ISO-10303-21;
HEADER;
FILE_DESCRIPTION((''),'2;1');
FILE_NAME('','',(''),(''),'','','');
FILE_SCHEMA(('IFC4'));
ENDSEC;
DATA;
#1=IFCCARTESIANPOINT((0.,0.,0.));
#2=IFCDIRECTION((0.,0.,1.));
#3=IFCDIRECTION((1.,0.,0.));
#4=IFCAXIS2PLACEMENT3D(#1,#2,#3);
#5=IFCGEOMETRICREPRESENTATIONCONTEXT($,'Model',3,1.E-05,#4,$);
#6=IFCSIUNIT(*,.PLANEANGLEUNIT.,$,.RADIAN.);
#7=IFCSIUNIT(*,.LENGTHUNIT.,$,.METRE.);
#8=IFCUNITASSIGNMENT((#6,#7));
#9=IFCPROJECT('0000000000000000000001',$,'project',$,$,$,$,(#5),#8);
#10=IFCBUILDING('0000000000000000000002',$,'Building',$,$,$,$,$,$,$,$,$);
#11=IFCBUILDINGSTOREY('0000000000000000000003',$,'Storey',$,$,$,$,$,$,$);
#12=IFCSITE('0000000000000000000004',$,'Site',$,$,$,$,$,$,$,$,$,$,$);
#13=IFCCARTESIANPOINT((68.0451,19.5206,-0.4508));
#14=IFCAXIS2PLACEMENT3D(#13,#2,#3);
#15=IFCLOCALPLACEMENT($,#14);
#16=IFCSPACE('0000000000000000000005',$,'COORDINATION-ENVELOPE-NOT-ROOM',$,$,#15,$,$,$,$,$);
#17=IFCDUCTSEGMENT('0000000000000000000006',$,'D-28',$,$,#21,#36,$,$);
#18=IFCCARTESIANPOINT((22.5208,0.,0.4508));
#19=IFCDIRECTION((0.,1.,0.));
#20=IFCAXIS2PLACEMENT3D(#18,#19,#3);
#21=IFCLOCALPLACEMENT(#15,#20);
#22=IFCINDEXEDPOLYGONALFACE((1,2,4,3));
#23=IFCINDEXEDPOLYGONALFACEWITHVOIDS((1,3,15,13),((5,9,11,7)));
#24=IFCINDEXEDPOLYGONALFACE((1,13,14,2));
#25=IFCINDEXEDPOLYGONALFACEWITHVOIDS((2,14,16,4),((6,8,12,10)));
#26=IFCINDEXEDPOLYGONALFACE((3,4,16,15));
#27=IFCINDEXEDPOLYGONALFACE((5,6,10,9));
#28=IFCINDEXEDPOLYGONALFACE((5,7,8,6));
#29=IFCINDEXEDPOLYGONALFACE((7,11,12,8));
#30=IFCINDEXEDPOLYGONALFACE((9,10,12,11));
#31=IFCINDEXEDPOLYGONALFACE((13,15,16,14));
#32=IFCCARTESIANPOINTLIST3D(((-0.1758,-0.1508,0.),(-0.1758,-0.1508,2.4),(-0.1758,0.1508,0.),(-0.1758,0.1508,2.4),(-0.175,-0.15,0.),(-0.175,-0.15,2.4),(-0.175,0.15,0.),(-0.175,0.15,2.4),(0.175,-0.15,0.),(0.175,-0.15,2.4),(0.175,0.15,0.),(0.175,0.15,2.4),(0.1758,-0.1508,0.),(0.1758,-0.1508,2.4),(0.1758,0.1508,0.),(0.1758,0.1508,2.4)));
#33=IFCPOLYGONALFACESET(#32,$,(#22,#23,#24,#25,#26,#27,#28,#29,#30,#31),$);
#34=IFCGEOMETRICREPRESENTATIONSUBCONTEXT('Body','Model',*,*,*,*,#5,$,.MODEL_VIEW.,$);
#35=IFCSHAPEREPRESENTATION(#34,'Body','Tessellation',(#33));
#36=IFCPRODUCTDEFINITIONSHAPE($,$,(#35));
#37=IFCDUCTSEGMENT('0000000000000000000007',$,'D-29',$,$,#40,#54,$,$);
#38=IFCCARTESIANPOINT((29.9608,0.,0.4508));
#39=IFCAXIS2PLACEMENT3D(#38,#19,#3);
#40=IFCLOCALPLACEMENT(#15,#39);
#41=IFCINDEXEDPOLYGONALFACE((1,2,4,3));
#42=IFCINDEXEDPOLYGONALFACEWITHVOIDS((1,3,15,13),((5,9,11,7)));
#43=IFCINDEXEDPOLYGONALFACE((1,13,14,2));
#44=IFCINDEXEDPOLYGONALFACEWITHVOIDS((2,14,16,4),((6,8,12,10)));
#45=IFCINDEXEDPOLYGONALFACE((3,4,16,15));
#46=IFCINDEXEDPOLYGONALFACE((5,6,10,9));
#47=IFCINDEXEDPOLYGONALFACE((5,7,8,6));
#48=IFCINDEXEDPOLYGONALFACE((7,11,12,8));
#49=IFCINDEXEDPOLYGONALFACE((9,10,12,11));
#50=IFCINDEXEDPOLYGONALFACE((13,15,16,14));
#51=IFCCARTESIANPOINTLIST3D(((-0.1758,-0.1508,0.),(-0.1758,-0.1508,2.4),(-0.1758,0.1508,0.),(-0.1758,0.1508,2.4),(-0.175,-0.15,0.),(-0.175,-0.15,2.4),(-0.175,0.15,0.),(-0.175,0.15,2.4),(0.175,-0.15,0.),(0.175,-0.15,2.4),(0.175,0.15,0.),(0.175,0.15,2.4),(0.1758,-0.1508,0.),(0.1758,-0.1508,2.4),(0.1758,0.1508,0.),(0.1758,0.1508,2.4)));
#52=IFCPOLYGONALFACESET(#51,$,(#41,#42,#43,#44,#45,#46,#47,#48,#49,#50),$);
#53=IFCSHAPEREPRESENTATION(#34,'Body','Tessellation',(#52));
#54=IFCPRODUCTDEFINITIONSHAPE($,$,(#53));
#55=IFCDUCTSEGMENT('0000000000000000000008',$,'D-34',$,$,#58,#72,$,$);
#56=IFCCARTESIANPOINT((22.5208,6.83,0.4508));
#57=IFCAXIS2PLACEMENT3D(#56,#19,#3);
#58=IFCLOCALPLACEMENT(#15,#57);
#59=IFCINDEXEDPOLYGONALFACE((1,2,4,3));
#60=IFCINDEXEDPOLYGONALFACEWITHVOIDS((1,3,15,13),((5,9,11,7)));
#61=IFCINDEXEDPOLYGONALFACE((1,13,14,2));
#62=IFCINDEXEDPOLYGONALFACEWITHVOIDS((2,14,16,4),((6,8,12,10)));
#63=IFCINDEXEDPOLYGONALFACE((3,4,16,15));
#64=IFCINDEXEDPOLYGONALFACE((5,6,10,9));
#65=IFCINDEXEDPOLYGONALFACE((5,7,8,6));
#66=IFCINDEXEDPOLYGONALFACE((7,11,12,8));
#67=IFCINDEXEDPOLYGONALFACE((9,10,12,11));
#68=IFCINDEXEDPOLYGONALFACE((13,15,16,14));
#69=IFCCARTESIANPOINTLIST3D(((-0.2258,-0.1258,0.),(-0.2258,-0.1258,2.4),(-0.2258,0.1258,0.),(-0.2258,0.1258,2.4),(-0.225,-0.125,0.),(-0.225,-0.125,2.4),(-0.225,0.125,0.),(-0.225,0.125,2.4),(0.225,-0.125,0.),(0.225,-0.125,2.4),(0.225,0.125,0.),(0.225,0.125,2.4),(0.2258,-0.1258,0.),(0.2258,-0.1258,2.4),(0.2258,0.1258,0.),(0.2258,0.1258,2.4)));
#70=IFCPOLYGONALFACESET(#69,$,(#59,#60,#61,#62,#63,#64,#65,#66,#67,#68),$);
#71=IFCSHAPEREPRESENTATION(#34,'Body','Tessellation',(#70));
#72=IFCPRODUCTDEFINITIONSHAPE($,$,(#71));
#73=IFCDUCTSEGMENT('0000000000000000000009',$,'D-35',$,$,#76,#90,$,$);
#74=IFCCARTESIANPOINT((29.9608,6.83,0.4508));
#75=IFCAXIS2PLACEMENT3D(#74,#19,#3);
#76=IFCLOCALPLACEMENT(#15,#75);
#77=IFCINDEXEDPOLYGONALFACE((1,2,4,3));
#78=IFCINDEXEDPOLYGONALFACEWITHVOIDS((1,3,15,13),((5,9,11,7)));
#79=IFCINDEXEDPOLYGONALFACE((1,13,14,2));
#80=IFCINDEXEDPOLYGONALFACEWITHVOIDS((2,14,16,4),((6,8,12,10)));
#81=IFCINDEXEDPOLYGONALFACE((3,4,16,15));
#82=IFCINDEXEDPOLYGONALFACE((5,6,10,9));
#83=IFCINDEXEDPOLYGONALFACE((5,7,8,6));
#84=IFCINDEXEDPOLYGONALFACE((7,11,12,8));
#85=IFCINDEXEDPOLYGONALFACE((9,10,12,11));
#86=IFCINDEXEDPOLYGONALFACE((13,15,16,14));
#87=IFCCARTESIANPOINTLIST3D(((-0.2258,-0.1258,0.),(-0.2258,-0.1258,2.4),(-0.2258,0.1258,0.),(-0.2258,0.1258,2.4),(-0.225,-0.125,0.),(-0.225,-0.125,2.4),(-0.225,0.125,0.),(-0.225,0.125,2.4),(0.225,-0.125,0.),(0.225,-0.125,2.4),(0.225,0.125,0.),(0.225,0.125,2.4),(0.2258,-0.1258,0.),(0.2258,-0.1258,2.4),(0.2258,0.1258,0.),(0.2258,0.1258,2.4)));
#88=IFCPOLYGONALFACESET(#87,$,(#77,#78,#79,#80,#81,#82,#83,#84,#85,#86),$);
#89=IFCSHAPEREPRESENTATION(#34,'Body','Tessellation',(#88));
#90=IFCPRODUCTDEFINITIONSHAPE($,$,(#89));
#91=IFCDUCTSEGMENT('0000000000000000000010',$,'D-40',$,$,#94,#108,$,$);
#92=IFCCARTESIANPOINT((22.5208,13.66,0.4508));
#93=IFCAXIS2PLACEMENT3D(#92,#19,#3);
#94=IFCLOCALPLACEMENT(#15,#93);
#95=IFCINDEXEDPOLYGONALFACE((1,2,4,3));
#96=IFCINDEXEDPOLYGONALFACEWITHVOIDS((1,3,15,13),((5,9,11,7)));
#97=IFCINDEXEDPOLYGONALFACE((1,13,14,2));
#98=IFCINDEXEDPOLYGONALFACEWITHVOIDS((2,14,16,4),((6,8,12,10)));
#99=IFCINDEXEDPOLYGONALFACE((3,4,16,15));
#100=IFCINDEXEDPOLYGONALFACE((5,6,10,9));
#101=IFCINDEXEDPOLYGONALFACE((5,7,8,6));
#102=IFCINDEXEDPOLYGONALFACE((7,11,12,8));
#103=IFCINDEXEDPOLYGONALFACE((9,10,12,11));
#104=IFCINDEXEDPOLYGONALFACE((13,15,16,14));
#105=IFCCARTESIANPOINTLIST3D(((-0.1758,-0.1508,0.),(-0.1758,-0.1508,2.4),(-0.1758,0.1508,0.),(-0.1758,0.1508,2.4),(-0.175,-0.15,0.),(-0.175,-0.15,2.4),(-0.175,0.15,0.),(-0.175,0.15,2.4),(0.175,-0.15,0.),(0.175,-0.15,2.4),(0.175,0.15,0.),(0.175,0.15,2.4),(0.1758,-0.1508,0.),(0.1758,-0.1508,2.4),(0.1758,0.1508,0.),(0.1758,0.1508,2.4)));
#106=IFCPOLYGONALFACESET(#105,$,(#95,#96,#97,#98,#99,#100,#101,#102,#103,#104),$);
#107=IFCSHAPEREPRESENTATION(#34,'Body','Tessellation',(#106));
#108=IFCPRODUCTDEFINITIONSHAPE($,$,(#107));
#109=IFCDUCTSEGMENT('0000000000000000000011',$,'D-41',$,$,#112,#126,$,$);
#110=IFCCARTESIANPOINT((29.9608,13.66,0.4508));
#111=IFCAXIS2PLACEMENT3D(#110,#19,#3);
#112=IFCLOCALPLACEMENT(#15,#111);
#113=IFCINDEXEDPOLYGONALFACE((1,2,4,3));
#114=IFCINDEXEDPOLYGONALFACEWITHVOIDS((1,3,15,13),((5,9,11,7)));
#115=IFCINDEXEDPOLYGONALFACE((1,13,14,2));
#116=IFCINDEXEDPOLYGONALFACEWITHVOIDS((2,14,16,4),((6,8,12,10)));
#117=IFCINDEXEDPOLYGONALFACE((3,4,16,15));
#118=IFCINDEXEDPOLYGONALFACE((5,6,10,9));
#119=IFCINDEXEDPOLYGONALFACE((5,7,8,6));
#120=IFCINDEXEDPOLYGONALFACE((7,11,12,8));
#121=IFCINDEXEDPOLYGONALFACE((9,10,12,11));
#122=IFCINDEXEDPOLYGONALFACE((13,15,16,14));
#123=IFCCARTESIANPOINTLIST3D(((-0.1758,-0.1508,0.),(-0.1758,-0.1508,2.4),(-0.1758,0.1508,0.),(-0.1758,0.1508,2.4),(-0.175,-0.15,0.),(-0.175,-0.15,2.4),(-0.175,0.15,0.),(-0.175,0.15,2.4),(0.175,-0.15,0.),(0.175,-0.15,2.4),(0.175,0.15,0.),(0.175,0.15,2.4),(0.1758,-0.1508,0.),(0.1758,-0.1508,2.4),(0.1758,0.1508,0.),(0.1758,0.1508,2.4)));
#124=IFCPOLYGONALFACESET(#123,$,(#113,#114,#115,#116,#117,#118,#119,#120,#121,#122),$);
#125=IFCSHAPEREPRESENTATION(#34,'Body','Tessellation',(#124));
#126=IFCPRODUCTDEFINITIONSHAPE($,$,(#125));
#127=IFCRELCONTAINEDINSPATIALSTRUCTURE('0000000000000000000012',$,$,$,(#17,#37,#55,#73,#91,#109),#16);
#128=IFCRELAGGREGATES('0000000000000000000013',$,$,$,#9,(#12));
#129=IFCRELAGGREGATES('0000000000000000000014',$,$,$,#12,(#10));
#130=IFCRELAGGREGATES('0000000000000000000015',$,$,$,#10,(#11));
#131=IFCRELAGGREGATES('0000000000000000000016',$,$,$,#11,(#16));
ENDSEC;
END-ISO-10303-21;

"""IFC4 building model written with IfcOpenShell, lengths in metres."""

from ifc_helpers import new_model, si_unit, frame, origin, origin_with_axes, place, context, subcontext, project, spatial, hollow_rectangle, extrude, element, save


model = new_model("IFC4")

# Units and contexts
model_context = context("Model", 3, precision=1e-05, world=origin_with_axes())
body_context = subcontext(model_context, "Body", "Model", "MODEL_VIEW")
ifc_project = project(units=[si_unit("PLANEANGLEUNIT", "RADIAN"), si_unit("LENGTHUNIT", "METRE")], contexts=[model_context])

# Site, building, storey, space
site = spatial("IfcSite", under=ifc_project, Name="Site")
building = spatial("IfcBuilding", under=site, Name="Building")
storey = spatial("IfcBuildingStorey", under=building, Name="Storey")
space_placement = place(None, frame((68.0451, 19.5206, -0.4508), z_axis=(0.0, 0.0, 1.0), x_axis=(1.0, 0.0, 0.0)))
space = spatial("IfcSpace", under=storey, at=space_placement, Name="COORDINATION-ENVELOPE-NOT-ROOM")

# Duct segments
for number, where, z_axis, x_axis, name in (
    (1, (22.5208, 0.0, 0.4508), (0.0, 1.0, 0.0), (1.0, 0.0, 0.0), "D-28"),
    (2, (29.9608, 0.0, 0.4508), (0.0, 1.0, 0.0), (1.0, 0.0, 0.0), "D-29"),
):
    element("IfcDuctSegment", number, at=place(space_placement, frame(where, z_axis=z_axis, x_axis=x_axis)), inside=space, Name=name, context=body_context, shape_type="SweptSolid", body=[
        extrude(hollow_rectangle(XDim=0.3516, YDim=0.3016, WallThickness=0.0008), origin(), (0.0, 0.0, 1.0), 2.4),
    ])
for number, where, z_axis, x_axis, name in (
    (3, (22.5208, 6.83, 0.4508), (0.0, 1.0, 0.0), (1.0, 0.0, 0.0), "D-34"),
    (4, (29.9608, 6.83, 0.4508), (0.0, 1.0, 0.0), (1.0, 0.0, 0.0), "D-35"),
):
    element("IfcDuctSegment", number, at=place(space_placement, frame(where, z_axis=z_axis, x_axis=x_axis)), inside=space, Name=name, context=body_context, shape_type="SweptSolid", body=[
        extrude(hollow_rectangle(XDim=0.4516, YDim=0.2516, WallThickness=0.0008), origin(), (0.0, 0.0, 1.0), 2.4),
    ])
for number, where, z_axis, x_axis, name in (
    (5, (22.5208, 13.66, 0.4508), (0.0, 1.0, 0.0), (1.0, 0.0, 0.0), "D-40"),
    (6, (29.9608, 13.66, 0.4508), (0.0, 1.0, 0.0), (1.0, 0.0, 0.0), "D-41"),
):
    element("IfcDuctSegment", number, at=place(space_placement, frame(where, z_axis=z_axis, x_axis=x_axis)), inside=space, Name=name, context=body_context, shape_type="SweptSolid", body=[
        extrude(hollow_rectangle(XDim=0.3516, YDim=0.3016, WallThickness=0.0008), origin(), (0.0, 0.0, 1.0), 2.4),
    ])

save(model, "model.ifc")
